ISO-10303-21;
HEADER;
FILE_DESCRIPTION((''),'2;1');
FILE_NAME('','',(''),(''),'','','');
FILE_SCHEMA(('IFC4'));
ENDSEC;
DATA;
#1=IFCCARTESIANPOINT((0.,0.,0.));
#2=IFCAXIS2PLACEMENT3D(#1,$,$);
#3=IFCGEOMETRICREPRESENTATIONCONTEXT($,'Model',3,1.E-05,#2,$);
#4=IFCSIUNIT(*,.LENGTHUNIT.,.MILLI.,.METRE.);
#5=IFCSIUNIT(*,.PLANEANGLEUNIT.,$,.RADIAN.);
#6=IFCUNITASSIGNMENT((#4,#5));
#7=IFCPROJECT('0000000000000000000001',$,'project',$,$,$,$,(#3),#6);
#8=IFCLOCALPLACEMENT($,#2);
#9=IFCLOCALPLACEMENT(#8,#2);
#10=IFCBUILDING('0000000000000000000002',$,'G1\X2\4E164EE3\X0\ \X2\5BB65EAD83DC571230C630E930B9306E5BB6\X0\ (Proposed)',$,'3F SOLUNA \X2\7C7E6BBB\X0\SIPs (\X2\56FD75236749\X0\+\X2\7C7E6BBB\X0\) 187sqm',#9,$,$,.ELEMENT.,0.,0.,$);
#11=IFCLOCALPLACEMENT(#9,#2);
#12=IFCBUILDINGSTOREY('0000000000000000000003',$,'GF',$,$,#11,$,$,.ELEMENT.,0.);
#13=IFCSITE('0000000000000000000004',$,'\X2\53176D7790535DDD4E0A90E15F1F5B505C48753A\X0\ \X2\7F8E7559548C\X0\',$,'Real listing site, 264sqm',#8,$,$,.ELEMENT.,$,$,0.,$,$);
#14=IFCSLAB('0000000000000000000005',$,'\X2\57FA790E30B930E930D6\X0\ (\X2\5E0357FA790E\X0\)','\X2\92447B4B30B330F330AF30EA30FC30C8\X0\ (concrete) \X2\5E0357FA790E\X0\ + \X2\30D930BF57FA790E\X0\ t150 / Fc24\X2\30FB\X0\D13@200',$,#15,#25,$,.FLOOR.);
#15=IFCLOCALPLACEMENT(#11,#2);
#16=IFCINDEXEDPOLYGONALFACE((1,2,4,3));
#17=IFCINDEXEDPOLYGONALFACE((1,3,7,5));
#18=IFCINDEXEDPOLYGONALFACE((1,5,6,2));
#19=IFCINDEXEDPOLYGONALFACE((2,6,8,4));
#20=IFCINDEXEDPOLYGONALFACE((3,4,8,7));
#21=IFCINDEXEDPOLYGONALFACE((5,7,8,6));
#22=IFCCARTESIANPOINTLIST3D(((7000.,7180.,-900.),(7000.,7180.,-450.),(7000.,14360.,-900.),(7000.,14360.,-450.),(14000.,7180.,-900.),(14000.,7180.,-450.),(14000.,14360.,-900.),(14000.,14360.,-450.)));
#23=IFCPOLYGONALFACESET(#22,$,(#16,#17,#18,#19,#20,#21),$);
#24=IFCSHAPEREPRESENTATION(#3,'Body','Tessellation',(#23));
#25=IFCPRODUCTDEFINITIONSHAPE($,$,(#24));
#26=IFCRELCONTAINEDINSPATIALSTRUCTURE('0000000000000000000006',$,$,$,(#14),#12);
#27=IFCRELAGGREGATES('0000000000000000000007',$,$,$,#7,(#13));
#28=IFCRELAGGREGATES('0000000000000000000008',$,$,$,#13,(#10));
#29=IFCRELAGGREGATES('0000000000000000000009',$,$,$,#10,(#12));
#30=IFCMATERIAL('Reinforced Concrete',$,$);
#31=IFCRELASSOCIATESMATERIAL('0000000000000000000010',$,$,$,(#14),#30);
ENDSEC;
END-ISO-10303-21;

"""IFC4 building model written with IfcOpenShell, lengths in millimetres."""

from ifc_helpers import new_model, si_unit, frame, frame_2d, origin, place, context, project, spatial, rectangle, extrude, material, element, save


model = new_model("IFC4")

# Units and contexts
model_context = context("Model", 3, precision=1e-05, world=origin())
ifc_project = project(units=[si_unit("LENGTHUNIT", "METRE", prefix="MILLI"), si_unit("PLANEANGLEUNIT", "RADIAN")], contexts=[model_context])

# Site, building, storey
site_placement = place(None, origin())
site = spatial("IfcSite", under=ifc_project, at=site_placement, Name="北海道川上郡弟子屈町 美留和", ObjectType="Real listing site, 264sqm", CompositionType="ELEMENT", RefElevation=0.0)
building_placement = place(site_placement, origin())
building = spatial("IfcBuilding", under=site, at=building_placement, Name="G1世代 家庭菜園テラスの家 (Proposed)", ObjectType="3F SOLUNA 籾殻SIPs (国産杉+籾殻) 187sqm", CompositionType="ELEMENT", ElevationOfRefHeight=0.0, ElevationOfTerrain=0.0)
storey_placement = place(building_placement, origin())
storey = spatial("IfcBuildingStorey", under=building, at=storey_placement, Name="GF", CompositionType="ELEMENT", Elevation=0.0)

# Slab
ifc_material_1 = material(Name="Reinforced Concrete")
slab_1_placement = place(storey_placement, frame((3500.0, 3590.0, -450.0)))
element("IfcSlab", 1, at=slab_1_placement, inside=storey, material=ifc_material_1, Name="基礎スラブ (布基礎)", Description="鉄筋コンクリート (concrete) 布基礎 + ベタ基礎 t150 / Fc24・D13@200", PredefinedType="FLOOR", context=model_context, shape_type="SweptSolid", body=[
    extrude(rectangle(XDim=7000.0, YDim=7180.0, at=frame_2d((3500.0, 3590.0))), frame((3500.0, 3590.0, -450.0)), (0.0, 0.0, 1.0), 450.0),
])

save(model, "model.ifc")
